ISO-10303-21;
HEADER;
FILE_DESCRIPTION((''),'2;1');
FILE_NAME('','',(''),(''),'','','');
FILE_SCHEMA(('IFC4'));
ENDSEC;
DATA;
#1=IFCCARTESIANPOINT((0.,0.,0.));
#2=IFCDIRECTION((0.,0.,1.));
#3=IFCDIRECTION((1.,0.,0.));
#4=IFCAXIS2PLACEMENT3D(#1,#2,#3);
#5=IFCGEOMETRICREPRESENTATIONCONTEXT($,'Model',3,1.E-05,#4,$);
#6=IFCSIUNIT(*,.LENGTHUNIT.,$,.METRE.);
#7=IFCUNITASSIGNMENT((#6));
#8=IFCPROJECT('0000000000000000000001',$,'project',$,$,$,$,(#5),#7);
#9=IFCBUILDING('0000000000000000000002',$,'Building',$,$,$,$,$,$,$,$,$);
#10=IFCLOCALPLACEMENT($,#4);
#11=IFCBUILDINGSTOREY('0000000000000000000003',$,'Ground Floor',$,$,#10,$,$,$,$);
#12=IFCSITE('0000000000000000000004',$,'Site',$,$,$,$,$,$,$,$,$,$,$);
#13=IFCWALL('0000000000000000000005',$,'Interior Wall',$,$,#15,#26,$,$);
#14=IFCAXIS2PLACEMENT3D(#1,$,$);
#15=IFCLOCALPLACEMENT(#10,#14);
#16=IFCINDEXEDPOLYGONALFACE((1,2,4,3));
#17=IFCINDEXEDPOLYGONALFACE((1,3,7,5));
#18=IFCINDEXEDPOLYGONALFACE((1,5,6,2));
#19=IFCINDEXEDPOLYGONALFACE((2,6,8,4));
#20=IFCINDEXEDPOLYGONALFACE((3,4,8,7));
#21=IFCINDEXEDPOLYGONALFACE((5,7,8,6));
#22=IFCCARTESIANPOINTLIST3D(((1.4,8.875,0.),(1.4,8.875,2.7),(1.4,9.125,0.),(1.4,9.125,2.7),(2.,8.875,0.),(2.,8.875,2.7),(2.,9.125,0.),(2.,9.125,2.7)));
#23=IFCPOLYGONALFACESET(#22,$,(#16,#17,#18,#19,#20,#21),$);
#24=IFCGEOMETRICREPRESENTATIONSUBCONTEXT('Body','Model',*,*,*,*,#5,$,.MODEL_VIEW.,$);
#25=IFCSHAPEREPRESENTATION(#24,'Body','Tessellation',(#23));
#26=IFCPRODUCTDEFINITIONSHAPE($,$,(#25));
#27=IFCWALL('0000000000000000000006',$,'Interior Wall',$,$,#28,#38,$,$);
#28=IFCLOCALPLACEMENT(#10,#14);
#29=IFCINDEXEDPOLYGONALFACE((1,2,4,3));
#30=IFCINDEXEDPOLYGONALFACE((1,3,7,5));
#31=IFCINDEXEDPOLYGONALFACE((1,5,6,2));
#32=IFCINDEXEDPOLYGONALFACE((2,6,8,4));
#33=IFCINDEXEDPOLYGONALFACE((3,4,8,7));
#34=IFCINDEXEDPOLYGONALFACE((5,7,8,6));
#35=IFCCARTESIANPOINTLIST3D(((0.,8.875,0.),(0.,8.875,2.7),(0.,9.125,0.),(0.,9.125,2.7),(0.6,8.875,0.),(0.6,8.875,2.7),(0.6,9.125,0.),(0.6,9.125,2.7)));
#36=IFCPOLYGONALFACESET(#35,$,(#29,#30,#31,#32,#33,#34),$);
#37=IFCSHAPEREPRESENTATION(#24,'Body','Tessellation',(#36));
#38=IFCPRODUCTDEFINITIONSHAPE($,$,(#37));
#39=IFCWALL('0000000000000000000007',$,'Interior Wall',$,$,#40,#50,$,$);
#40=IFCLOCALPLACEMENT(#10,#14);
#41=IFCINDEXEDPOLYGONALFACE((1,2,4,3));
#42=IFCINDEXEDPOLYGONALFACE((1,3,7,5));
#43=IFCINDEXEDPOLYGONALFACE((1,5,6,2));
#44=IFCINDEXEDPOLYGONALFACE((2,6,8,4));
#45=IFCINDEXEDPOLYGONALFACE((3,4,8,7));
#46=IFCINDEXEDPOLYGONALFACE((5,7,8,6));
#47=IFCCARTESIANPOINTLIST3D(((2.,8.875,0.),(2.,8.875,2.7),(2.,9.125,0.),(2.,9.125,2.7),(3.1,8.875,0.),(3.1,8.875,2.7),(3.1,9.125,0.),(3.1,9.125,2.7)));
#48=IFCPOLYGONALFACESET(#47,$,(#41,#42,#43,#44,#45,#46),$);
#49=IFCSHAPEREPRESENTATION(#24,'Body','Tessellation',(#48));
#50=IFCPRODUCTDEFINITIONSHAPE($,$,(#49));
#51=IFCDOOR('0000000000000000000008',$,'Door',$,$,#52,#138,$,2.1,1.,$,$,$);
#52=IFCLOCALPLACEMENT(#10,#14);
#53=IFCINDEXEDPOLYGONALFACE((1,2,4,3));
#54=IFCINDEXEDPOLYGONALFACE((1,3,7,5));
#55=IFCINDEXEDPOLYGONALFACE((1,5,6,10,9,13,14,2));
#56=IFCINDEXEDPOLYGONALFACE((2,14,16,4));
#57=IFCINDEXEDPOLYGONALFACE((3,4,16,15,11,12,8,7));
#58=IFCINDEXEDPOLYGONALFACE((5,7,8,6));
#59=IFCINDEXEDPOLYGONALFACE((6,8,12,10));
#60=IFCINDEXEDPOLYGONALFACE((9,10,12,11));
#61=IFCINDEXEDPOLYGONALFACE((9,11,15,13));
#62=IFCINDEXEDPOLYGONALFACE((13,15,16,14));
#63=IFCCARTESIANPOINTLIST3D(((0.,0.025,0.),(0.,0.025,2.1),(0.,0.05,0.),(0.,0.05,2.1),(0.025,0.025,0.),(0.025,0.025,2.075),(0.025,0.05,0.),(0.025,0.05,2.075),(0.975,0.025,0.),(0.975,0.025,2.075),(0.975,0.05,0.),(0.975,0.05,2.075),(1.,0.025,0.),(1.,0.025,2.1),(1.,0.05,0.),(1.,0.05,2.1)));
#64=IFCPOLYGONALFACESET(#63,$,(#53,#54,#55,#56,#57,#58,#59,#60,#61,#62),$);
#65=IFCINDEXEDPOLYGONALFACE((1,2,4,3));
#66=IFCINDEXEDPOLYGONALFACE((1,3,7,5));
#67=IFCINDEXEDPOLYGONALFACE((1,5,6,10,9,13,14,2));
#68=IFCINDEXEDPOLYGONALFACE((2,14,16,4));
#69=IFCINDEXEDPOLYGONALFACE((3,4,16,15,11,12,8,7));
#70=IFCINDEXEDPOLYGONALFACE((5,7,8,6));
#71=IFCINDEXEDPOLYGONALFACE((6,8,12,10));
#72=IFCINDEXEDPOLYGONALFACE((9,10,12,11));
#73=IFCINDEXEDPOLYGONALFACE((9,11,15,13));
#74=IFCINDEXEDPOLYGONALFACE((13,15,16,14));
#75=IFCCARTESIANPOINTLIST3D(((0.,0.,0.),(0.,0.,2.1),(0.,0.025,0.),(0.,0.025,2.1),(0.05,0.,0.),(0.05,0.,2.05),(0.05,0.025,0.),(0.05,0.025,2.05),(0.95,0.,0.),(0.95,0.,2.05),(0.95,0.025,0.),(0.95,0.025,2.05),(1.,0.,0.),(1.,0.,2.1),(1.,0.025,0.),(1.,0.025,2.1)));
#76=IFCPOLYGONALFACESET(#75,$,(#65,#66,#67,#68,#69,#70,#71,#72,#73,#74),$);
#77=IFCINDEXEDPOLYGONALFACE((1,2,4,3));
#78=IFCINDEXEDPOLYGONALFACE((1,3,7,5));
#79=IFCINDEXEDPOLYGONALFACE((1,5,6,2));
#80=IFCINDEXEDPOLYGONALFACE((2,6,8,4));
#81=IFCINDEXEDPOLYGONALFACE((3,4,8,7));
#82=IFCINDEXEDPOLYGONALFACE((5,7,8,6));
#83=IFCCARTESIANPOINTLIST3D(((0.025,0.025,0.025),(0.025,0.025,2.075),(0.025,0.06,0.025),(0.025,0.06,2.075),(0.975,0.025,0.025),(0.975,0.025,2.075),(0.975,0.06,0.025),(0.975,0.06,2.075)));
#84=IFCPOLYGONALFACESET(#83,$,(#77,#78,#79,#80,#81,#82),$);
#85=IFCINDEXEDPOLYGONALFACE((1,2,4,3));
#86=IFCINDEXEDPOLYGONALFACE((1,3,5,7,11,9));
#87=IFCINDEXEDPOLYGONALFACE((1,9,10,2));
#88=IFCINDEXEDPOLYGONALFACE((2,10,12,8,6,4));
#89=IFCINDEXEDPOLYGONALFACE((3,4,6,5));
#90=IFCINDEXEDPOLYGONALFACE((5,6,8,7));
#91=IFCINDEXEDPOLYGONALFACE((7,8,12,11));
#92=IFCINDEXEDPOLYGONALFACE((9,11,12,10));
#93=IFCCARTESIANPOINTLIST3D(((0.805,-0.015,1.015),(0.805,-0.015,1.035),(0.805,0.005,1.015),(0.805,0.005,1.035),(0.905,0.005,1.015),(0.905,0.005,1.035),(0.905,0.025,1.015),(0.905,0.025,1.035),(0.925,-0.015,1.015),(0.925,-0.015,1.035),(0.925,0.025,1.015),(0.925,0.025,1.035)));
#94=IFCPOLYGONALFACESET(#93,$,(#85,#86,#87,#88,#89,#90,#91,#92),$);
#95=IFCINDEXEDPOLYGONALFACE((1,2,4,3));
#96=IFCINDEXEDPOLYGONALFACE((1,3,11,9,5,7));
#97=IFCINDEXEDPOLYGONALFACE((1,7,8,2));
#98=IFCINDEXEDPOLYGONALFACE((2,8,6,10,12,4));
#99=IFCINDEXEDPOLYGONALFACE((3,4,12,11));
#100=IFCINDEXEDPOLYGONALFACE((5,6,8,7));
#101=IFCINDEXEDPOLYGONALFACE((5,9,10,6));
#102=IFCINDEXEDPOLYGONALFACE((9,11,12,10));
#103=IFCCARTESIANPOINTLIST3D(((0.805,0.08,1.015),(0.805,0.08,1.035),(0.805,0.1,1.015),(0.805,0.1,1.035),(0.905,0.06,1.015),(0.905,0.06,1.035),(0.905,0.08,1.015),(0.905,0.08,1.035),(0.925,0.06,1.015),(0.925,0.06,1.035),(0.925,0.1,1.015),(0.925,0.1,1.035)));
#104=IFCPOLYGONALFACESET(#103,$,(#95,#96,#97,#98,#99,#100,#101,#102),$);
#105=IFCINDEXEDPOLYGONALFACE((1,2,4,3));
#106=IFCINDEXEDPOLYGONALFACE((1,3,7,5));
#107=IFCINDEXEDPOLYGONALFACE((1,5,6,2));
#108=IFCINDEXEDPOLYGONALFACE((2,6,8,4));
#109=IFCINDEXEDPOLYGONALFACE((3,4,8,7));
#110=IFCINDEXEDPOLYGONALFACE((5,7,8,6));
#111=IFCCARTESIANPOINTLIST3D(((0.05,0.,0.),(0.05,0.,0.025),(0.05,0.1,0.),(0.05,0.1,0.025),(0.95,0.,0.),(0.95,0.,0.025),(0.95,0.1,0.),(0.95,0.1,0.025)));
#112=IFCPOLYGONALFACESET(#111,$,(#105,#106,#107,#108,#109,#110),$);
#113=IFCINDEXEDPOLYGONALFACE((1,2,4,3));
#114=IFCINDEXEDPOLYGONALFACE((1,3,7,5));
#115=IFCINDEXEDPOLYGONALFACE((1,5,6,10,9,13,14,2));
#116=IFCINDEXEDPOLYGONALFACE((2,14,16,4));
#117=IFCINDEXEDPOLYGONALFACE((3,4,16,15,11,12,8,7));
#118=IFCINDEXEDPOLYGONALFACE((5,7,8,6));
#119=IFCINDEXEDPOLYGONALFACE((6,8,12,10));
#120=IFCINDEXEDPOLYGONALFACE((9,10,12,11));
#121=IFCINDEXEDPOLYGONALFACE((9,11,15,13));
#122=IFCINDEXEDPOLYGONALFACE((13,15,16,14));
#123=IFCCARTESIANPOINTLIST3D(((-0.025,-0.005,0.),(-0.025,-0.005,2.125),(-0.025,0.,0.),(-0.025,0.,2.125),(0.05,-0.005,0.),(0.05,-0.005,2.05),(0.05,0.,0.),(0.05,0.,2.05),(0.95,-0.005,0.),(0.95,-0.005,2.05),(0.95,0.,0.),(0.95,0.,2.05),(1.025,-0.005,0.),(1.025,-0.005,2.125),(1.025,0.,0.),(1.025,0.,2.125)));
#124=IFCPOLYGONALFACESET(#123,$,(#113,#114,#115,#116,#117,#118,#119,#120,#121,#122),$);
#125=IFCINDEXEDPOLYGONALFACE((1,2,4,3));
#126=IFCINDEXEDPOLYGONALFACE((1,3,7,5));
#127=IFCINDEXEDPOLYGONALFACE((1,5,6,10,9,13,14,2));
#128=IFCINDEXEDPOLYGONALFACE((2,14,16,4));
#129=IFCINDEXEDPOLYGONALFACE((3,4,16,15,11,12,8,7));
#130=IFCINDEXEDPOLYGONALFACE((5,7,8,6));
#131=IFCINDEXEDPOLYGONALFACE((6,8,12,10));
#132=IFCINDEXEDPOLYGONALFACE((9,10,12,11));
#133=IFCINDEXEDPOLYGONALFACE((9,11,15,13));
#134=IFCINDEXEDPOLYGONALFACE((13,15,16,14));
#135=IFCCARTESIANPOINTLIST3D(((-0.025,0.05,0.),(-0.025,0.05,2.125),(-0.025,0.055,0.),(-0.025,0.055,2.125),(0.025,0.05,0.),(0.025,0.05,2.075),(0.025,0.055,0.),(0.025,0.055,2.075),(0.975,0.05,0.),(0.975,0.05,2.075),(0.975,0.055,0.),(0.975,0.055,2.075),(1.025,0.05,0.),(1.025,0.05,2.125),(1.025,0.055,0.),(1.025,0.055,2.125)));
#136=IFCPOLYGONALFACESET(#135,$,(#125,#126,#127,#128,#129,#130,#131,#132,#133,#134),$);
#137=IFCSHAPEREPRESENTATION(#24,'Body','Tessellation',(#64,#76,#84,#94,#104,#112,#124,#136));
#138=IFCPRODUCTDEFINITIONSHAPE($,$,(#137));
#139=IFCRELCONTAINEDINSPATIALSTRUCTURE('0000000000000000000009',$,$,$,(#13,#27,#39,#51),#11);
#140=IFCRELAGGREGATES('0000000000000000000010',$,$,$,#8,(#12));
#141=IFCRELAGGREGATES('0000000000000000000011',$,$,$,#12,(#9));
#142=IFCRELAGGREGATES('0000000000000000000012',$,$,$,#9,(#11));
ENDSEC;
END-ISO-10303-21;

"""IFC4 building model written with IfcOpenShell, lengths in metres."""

from ifc_helpers import new_model, si_unit, frame, origin_with_axes, place, context, subcontext, project, spatial, line, indexed_curve, outline, extrude, element, save


model = new_model("IFC4")

# Units and contexts
model_context = context("Model", 3, precision=1e-05, world=origin_with_axes())
body_context = subcontext(model_context, "Body", "Model", "MODEL_VIEW")
ifc_project = project(units=[si_unit("LENGTHUNIT", "METRE")], contexts=[model_context])

# Site, building, storey
site = spatial("IfcSite", under=ifc_project, Name="Site")
building = spatial("IfcBuilding", under=site, Name="Building")
storey_placement = place(None, origin_with_axes())
storey = spatial("IfcBuildingStorey", under=building, at=storey_placement, Name="Ground Floor")

# Walls
for number, where, z_axis, x_axis, name in (
    (1, (2.0, 9.0, 0.0), (0.0, 0.0, 1.0), (-1.0, 0.0, 0.0), "Interior Wall"),
    (2, (0.6, 9.0, 0.0), (0.0, 0.0, 1.0), (-1.0, 0.0, 0.0), "Interior Wall"),
):
    element("IfcWall", number, at=place(storey_placement, frame(where, z_axis=z_axis, x_axis=x_axis)), inside=storey, Name=name, context=body_context, shape_type="SweptSolid", body=[
        extrude(outline(indexed_curve([(0.0, 0.0), (0.0, 0.25), (0.6, 0.25), (0.6, 0.0), (0.0, 0.0)], self_intersect=False)), frame((0.0, -0.125, 0.0), z_axis=(0.0, 0.0, 1.0), x_axis=(1.0, 0.0, 0.0)), (0.0, 0.0, 1.0), 2.7),
    ])
wall_1_placement = place(storey_placement, frame((3.1, 9.0, 0.0), z_axis=(0.0, 0.0, 1.0), x_axis=(-1.0, 0.0, 0.0)))
element("IfcWall", 3, at=wall_1_placement, inside=storey, Name="Interior Wall", context=body_context, shape_type="SweptSolid", body=[
    extrude(outline(indexed_curve([(0.0, 0.0), (0.0, 0.25), (1.1, 0.25), (1.1, 0.0), (0.0, 0.0)], self_intersect=False)), frame((0.0, -0.125, 0.0), z_axis=(0.0, 0.0, 1.0), x_axis=(1.0, 0.0, 0.0)), (0.0, 0.0, 1.0), 2.7),
])

# Door
door_1_placement = place(storey_placement, origin_with_axes())
element("IfcDoor", 4, at=door_1_placement, inside=storey, Name="Door", OverallHeight=2.1, OverallWidth=1.0, context=body_context, shape_type="SweptSolid", body=[
    extrude(outline(indexed_curve([(0.0, 0.0), (0.0, 2.1), (1.0, 2.1), (1.0, 0.0), (0.975, 0.0), (0.975, 2.075), (0.025, 2.075), (0.025, 0.0)], segments=[line(1, 2, 3, 4, 5, 6, 7, 8, 1)])), frame((0.0, 0.025, 0.0), z_axis=(0.0, -1.0, 0.0), x_axis=(1.0, 0.0, 0.0)), (0.0, 0.0, -1.0), 0.025),
    extrude(outline(indexed_curve([(0.0, 0.0), (0.0, 2.1), (1.0, 2.1), (1.0, 0.0), (0.95, 0.0), (0.95, 2.05), (0.05, 2.05), (0.05, 0.0)], segments=[line(1, 2, 3, 4, 5, 6, 7, 8, 1)])), frame((0.0, 0.0, 0.0), z_axis=(0.0, -1.0, 0.0), x_axis=(1.0, 0.0, 0.0)), (0.0, 0.0, -1.0), 0.025),
    extrude(outline(indexed_curve([(0.0, 0.0), (0.95, 0.0), (0.95, 0.035), (0.0, 0.035)], segments=[line(1, 2, 3, 4, 1)])), frame((0.025, 0.025, 0.025), z_axis=(0.0, 0.0, 1.0), x_axis=(1.0, 0.0, 0.0)), (0.0, 0.0, 1.0), 2.05),
    extrude(outline(indexed_curve([(0.0, 0.0), (0.0, -0.04), (-0.12, -0.04), (-0.12, -0.02), (-0.02, -0.02), (-0.02, 0.0)], segments=[line(1, 2, 3, 4, 5, 6, 1)])), frame((0.925, 0.025, 1.015), z_axis=(0.0, 0.0, 1.0), x_axis=(1.0, 0.0, 0.0)), (0.0, 0.0, 1.0), 0.02),
    extrude(outline(indexed_curve([(0.0, 0.0), (0.0, 0.04), (-0.12, 0.04), (-0.12, 0.02), (-0.02, 0.02), (-0.02, 0.0)], segments=[line(1, 2, 3, 4, 5, 6, 1)])), frame((0.925, 0.06, 1.015), z_axis=(0.0, 0.0, 1.0), x_axis=(1.0, 0.0, 0.0)), (0.0, 0.0, 1.0), 0.02),
    extrude(outline(indexed_curve([(0.0, 0.0), (0.9, 0.0), (0.9, 0.1), (0.0, 0.1)], segments=[line(1, 2, 3, 4, 1)])), frame((0.05, 0.0, 0.0), z_axis=(0.0, 0.0, 1.0), x_axis=(1.0, 0.0, 0.0)), (0.0, 0.0, 1.0), 0.025),
    extrude(outline(indexed_curve([(0.0, 0.0), (0.0, 2.125), (1.05, 2.125), (1.05, 0.0), (0.975, 0.0), (0.975, 2.05), (0.075, 2.05), (0.075, 0.0)], segments=[line(1, 2, 3, 4, 5, 6, 7, 8, 1)])), frame((-0.025, -0.005, 0.0), z_axis=(0.0, -1.0, 0.0), x_axis=(1.0, 0.0, 0.0)), (0.0, 0.0, -1.0), 0.005),
    extrude(outline(indexed_curve([(0.0, 0.0), (0.0, 2.125), (1.05, 2.125), (1.05, 0.0), (1.0, 0.0), (1.0, 2.075), (0.05, 2.075), (0.05, 0.0)], segments=[line(1, 2, 3, 4, 5, 6, 7, 8, 1)])), frame((-0.025, 0.05, 0.0), z_axis=(0.0, -1.0, 0.0), x_axis=(1.0, 0.0, 0.0)), (0.0, 0.0, -1.0), 0.005),
])

save(model, "model.ifc")
